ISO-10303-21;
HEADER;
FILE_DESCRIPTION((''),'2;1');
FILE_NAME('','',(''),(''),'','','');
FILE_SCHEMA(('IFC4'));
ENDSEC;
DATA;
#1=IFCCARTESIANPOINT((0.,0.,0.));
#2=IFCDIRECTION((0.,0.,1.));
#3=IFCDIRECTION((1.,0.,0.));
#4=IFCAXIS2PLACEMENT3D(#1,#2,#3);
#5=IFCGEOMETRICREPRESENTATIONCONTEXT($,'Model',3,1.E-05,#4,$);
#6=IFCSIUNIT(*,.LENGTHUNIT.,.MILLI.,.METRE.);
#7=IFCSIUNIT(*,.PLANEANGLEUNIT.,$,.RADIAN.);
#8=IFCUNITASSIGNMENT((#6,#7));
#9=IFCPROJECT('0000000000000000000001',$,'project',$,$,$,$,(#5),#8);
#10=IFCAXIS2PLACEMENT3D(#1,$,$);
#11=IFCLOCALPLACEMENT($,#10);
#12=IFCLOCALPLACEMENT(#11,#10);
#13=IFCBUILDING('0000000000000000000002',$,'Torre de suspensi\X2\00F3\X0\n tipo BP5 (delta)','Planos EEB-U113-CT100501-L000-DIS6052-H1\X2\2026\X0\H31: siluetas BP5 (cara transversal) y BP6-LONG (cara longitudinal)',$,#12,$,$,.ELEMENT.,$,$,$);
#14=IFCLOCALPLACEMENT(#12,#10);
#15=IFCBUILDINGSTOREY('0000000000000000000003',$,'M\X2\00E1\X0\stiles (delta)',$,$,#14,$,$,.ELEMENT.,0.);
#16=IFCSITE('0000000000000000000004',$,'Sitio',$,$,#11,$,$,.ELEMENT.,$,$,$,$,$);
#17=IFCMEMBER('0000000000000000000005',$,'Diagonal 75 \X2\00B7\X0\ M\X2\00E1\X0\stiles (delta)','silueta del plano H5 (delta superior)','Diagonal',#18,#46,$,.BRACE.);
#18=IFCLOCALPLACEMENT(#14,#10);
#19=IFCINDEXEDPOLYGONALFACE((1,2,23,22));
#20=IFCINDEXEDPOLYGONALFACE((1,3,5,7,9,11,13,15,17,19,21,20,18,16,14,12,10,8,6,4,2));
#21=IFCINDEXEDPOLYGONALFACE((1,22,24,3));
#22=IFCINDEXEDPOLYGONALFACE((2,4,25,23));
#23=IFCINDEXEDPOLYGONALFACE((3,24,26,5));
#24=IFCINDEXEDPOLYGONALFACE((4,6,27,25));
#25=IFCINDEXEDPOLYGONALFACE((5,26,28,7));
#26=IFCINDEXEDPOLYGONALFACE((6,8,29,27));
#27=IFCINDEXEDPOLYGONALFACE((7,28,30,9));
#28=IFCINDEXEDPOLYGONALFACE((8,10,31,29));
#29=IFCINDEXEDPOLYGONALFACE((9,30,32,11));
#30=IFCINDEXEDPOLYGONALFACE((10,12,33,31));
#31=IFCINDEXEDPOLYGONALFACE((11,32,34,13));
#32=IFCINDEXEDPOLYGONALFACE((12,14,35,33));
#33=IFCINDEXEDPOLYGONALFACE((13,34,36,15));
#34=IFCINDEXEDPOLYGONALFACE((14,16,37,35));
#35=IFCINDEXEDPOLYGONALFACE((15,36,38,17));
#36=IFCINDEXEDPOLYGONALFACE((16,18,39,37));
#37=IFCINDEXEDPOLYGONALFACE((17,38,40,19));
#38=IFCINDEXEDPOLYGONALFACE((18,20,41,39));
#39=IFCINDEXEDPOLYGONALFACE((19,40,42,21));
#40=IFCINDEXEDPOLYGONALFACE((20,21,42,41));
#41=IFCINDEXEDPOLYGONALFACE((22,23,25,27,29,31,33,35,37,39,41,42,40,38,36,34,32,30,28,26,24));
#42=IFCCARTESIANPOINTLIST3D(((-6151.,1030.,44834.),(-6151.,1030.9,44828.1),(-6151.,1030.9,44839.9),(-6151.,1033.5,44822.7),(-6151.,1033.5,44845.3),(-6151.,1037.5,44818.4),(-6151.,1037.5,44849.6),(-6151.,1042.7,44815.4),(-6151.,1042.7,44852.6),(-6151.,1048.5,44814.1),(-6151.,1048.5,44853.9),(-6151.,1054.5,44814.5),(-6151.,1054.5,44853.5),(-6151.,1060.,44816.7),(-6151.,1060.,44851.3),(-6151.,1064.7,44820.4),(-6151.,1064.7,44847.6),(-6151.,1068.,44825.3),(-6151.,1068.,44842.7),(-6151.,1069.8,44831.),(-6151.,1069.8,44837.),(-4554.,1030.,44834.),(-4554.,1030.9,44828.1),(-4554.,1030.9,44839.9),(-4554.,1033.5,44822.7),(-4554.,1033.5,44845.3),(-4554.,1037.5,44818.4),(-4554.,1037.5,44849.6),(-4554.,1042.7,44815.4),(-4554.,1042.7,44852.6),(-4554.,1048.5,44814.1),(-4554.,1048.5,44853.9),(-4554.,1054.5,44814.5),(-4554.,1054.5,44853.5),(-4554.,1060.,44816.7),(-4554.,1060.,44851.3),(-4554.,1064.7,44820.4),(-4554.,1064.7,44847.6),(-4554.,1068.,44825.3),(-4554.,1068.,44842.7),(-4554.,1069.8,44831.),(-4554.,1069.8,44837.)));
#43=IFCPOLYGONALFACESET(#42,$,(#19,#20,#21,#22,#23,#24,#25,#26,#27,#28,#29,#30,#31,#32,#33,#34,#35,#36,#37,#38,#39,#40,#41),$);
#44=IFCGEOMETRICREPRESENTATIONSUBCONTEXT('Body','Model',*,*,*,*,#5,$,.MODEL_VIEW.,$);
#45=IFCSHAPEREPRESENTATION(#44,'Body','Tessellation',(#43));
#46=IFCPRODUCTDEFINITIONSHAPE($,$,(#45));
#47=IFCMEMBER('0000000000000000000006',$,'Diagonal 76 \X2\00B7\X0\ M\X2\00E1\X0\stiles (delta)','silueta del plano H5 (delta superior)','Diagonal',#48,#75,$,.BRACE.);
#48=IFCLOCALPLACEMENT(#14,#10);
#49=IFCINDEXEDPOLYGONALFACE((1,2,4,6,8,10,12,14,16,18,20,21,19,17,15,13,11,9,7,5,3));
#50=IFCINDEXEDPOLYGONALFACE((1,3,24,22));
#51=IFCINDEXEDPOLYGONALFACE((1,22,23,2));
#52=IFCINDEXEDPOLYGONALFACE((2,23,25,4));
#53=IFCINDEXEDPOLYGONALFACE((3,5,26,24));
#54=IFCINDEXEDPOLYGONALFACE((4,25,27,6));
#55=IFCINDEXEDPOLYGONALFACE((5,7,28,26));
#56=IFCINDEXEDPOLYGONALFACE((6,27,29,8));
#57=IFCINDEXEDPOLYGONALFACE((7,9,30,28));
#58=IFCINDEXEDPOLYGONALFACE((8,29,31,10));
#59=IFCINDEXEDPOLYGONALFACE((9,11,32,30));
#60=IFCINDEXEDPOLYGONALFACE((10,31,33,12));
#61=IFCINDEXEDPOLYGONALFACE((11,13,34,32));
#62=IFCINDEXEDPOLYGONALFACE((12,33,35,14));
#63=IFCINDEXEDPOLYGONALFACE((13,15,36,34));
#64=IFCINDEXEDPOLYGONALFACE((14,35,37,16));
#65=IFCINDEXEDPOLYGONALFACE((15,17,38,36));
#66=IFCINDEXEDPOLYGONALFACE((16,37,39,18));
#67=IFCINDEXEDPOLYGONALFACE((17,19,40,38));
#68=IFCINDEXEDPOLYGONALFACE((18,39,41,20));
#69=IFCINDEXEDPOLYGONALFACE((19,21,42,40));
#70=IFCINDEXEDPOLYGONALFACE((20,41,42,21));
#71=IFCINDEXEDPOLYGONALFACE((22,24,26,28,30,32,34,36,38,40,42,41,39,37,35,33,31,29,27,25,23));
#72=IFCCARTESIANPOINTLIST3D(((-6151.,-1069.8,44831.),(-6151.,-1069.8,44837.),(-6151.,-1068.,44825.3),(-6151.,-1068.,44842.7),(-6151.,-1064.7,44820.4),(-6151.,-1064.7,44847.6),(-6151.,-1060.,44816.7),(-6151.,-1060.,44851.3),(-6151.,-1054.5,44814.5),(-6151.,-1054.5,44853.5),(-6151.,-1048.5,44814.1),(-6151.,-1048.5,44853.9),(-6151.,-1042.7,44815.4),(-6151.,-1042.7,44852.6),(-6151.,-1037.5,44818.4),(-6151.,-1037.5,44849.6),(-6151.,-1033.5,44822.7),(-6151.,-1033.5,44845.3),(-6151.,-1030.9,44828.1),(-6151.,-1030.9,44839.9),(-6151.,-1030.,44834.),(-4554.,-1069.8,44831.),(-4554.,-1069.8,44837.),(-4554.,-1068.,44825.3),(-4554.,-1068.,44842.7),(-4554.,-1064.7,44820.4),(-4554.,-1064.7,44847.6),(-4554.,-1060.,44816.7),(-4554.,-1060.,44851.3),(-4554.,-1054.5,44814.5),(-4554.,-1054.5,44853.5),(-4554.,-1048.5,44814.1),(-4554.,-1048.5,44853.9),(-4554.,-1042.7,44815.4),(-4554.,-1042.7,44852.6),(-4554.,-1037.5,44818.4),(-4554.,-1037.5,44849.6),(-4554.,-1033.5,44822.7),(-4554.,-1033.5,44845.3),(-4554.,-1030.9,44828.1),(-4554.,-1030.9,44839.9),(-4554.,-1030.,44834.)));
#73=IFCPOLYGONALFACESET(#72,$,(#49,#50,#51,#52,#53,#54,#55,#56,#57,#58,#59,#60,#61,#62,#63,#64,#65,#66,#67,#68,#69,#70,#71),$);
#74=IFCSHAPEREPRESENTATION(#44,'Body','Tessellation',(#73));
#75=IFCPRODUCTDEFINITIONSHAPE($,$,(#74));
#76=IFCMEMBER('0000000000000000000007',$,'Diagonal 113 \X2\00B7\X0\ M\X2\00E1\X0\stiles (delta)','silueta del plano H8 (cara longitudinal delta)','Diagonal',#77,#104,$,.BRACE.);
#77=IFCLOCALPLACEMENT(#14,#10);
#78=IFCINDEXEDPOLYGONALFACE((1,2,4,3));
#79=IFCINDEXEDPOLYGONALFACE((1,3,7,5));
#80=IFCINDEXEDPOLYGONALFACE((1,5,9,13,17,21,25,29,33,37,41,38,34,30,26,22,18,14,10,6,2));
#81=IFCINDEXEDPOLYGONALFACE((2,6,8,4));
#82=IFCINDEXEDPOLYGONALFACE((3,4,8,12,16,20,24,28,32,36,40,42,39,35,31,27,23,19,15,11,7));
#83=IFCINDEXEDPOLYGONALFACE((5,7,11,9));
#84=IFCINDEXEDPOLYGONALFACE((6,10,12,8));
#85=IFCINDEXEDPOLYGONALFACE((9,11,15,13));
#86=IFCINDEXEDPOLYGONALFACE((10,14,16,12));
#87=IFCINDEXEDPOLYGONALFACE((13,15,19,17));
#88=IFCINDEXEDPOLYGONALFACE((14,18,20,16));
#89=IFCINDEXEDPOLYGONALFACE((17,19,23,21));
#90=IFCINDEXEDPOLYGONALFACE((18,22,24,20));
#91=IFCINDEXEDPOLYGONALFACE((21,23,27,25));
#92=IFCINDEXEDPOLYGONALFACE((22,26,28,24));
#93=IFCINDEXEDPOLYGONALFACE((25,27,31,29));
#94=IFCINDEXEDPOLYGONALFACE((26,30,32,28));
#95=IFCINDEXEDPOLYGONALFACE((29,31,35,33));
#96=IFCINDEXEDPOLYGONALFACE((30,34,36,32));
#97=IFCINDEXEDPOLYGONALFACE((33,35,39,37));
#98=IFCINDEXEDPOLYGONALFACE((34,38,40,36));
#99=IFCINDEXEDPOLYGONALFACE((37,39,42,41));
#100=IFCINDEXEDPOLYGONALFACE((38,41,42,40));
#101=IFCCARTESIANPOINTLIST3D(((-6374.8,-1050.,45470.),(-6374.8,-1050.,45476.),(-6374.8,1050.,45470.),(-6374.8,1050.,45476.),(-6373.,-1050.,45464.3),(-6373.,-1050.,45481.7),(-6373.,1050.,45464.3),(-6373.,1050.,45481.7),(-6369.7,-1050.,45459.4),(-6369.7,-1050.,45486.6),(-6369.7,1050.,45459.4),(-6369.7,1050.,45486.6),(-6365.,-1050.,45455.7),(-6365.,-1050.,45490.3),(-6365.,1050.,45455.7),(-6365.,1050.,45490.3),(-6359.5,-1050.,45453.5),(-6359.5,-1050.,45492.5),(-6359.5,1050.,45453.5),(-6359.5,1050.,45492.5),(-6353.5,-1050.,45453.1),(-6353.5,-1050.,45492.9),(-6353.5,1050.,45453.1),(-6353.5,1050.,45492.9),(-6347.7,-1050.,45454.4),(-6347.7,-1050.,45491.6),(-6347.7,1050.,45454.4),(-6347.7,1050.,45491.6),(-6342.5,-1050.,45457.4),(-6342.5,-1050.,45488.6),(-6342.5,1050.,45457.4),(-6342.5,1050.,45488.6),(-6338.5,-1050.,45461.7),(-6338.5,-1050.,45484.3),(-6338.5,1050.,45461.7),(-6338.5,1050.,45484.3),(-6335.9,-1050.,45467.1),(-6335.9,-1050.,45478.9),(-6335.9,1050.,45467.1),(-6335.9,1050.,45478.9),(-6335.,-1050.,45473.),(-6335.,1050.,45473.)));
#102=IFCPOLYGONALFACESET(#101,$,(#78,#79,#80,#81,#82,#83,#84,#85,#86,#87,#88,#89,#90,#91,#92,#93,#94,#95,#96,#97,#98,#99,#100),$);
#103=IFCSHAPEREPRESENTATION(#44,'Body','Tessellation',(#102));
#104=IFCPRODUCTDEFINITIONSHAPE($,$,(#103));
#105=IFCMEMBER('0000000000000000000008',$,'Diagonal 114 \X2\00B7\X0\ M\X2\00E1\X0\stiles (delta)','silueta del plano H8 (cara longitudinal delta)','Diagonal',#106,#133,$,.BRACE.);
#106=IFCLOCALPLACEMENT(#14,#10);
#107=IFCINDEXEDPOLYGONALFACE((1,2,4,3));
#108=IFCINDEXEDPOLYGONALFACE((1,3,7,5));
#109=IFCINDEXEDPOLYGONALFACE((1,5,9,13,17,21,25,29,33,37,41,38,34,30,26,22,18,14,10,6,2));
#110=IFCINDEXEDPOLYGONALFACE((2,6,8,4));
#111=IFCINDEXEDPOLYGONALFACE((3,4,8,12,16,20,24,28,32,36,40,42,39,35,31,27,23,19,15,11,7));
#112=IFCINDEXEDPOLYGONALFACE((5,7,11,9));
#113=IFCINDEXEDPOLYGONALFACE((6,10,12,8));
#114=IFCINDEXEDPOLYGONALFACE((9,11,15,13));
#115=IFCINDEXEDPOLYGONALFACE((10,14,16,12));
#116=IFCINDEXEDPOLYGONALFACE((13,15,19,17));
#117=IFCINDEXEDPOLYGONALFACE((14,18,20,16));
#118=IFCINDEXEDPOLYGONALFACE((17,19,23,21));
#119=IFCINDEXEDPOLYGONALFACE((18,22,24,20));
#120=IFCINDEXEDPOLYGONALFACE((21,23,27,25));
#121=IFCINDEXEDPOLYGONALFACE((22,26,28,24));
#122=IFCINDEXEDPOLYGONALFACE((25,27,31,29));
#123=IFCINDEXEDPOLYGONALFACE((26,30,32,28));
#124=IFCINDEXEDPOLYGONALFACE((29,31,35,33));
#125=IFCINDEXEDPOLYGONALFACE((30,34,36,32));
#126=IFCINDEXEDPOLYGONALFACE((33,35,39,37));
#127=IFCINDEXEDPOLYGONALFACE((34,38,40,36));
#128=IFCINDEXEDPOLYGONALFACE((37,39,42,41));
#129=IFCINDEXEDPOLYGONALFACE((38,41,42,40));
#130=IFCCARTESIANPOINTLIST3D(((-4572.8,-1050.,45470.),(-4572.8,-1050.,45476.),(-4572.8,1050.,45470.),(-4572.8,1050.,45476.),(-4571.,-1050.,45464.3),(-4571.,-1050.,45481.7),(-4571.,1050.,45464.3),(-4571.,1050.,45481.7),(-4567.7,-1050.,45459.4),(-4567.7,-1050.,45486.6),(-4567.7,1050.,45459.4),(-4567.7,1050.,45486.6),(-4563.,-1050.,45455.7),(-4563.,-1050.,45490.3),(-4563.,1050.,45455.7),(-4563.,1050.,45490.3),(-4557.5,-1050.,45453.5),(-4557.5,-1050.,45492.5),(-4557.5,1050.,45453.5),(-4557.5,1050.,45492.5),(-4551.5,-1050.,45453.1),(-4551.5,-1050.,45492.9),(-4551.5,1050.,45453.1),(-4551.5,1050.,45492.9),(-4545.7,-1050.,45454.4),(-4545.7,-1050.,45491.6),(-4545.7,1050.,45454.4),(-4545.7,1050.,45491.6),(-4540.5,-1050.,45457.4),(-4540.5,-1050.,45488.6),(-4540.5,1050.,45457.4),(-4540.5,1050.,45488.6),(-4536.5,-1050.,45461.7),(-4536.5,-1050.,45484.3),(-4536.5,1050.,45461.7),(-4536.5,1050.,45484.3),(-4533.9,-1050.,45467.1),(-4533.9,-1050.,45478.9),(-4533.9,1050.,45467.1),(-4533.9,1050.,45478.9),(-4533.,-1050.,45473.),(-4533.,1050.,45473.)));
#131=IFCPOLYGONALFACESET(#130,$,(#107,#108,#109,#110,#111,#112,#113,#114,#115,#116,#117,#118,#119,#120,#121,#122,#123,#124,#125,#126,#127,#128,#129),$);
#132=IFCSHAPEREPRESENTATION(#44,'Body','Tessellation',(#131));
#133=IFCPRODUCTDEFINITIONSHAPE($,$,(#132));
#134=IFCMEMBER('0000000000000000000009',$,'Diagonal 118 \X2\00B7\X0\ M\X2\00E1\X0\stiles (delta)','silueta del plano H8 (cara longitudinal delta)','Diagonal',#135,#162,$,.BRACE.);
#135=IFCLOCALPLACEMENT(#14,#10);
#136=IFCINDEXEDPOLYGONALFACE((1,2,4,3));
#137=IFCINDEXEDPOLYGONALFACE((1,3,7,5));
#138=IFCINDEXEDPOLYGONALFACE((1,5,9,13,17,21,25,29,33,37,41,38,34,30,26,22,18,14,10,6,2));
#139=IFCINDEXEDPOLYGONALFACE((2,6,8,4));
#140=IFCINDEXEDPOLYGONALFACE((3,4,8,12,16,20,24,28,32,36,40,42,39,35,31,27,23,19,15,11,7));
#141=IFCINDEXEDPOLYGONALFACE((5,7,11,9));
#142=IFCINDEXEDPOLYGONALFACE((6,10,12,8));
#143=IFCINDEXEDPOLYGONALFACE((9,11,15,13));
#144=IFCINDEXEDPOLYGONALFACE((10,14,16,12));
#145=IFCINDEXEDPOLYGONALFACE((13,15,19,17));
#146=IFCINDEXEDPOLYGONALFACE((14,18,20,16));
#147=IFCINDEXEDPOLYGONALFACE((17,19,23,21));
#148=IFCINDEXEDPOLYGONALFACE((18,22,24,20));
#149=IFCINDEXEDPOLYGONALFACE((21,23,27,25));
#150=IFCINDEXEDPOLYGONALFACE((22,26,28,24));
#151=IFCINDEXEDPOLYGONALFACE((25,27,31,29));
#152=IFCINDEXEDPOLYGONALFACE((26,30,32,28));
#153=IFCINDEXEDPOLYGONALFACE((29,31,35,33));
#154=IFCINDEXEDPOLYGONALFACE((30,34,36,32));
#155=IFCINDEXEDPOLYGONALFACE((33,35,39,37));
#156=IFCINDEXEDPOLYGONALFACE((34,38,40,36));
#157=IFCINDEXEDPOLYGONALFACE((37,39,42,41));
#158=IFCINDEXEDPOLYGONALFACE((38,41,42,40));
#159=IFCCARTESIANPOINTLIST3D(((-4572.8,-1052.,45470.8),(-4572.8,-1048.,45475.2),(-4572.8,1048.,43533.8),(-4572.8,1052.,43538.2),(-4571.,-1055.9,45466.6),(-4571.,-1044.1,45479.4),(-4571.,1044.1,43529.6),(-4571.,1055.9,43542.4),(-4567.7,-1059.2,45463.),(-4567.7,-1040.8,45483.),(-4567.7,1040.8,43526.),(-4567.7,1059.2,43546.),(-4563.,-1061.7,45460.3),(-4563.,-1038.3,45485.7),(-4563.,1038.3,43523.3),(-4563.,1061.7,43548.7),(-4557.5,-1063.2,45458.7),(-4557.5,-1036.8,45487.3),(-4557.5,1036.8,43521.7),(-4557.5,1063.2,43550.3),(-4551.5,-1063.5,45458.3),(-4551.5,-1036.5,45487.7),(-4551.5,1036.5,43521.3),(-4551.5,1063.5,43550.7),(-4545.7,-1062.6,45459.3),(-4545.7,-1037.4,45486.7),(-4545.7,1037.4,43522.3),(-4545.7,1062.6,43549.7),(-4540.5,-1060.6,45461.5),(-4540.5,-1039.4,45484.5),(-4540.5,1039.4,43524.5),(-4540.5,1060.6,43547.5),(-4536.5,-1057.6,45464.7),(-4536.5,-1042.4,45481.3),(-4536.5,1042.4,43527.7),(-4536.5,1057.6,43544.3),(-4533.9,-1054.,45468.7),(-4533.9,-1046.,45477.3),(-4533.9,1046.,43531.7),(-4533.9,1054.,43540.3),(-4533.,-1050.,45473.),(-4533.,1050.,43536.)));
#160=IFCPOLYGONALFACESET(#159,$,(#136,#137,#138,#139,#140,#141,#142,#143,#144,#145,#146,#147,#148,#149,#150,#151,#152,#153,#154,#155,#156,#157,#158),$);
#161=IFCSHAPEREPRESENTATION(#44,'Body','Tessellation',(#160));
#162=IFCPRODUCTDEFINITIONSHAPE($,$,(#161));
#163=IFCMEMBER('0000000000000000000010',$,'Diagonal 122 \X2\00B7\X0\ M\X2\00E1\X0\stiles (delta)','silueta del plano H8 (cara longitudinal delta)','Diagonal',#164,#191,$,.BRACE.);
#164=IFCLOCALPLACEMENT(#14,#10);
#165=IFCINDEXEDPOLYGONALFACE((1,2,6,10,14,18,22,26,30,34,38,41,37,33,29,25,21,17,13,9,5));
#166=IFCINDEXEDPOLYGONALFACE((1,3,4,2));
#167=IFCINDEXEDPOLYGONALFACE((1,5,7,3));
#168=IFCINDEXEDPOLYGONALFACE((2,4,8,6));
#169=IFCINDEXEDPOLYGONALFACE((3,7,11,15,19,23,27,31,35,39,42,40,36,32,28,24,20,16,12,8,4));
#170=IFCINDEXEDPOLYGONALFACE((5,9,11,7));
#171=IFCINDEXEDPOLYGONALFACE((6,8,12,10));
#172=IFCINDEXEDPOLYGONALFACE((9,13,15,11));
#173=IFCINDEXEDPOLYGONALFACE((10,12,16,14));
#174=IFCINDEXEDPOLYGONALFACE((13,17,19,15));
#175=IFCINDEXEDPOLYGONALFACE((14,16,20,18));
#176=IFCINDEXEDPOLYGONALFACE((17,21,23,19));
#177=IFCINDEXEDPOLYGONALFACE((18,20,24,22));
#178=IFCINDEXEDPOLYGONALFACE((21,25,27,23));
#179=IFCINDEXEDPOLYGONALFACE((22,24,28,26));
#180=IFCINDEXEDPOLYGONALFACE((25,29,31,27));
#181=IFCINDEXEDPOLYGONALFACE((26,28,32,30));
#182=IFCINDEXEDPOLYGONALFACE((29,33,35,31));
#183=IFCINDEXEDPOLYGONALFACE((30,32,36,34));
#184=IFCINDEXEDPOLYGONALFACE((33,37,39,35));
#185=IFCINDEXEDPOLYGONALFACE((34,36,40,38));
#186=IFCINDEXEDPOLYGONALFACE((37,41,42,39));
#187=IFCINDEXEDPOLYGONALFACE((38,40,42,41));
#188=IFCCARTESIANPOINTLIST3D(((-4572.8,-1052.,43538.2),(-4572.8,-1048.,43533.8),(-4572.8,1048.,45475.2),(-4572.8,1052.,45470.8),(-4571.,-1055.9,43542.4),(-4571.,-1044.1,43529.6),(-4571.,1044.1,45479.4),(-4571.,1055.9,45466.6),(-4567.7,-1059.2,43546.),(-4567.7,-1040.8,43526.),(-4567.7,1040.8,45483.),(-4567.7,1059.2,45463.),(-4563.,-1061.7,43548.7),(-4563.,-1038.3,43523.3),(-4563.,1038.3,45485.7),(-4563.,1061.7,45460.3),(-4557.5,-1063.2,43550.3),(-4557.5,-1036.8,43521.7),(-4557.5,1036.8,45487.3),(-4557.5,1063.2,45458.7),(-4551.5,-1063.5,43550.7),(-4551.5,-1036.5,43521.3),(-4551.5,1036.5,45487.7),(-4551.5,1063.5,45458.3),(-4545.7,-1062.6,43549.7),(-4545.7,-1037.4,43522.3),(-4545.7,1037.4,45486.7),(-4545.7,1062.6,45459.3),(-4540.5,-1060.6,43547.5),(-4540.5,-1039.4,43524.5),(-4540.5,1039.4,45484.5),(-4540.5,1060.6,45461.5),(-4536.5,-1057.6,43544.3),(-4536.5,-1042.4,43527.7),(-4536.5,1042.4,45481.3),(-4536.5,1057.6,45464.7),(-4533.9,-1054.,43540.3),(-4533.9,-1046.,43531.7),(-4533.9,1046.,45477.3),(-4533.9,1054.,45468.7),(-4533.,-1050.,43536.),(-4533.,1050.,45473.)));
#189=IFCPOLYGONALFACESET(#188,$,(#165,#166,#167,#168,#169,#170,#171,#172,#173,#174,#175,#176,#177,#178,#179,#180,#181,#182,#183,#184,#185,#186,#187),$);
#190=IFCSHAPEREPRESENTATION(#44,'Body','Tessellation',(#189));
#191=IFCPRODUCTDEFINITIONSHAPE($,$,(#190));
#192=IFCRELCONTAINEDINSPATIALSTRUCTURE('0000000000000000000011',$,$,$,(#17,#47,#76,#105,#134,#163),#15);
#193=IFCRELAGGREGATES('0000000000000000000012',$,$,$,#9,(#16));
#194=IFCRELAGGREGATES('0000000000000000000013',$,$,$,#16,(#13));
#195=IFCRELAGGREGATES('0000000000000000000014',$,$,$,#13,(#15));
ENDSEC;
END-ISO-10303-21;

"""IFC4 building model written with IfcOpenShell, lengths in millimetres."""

from ifc_helpers import new_model, si_unit, frame, origin, origin_with_axes, place, context, subcontext, project, spatial, circle, extrude, element, save


model = new_model("IFC4")

# Units and contexts
model_context = context("Model", 3, precision=1e-05, world=origin_with_axes())
body_context = subcontext(model_context, "Body", "Model", "MODEL_VIEW")
ifc_project = project(units=[si_unit("LENGTHUNIT", "METRE", prefix="MILLI"), si_unit("PLANEANGLEUNIT", "RADIAN")], contexts=[model_context])

# Site, building, storey
site_placement = place(None, origin())
site = spatial("IfcSite", under=ifc_project, at=site_placement, Name="Sitio", CompositionType="ELEMENT")
building_placement = place(site_placement, origin())
building = spatial("IfcBuilding", under=site, at=building_placement, Name="Torre de suspensión tipo BP5 (delta)", Description="Planos EEB-U113-CT100501-L000-DIS6052-H1…H31: siluetas BP5 (cara transversal) y BP6-LONG (cara longitudinal)", CompositionType="ELEMENT")
storey_placement = place(building_placement, origin())
storey = spatial("IfcBuildingStorey", under=building, at=storey_placement, Name="Mástiles (delta)", CompositionType="ELEMENT", Elevation=0.0)

# Members
for number, where, z_axis, x_axis, name in (
    (1, (-4554.0, 1050.0, 44834.0), (-1.0, 0.0, 0.0), (0.0, -1.0, 0.0), "Diagonal 75 · Mástiles (delta)"),
    (2, (-4554.0, -1050.0, 44834.0), (-1.0, 0.0, 0.0), (0.0, 1.0, 0.0), "Diagonal 76 · Mástiles (delta)"),
):
    element("IfcMember", number, at=place(storey_placement, frame(where, z_axis=z_axis, x_axis=x_axis)), inside=storey, Name=name, Description="silueta del plano H5 (delta superior)", ObjectType="Diagonal", PredefinedType="BRACE", context=body_context, shape_type="SweptSolid", body=[
        extrude(circle(Radius=20.0), None, (0.0, 0.0, 1.0), 1597.0),
    ])
for number, where, z_axis, x_axis, name in (
    (3, (-6355.0, -1050.0, 45473.0), (0.0, 1.0, 0.0), (1.0, 0.0, 0.0), "Diagonal 113 · Mástiles (delta)"),
    (4, (-4553.0, -1050.0, 45473.0), (0.0, 1.0, 0.0), (1.0, 0.0, 0.0), "Diagonal 114 · Mástiles (delta)"),
):
    element("IfcMember", number, at=place(storey_placement, frame(where, z_axis=z_axis, x_axis=x_axis)), inside=storey, Name=name, Description="silueta del plano H8 (cara longitudinal delta)", ObjectType="Diagonal", PredefinedType="BRACE", context=body_context, shape_type="SweptSolid", body=[
        extrude(circle(Radius=20.0), None, (0.0, 0.0, 1.0), 2100.0),
    ])
member_1_placement = place(storey_placement, frame((-4553.0, -1050.0, 45473.0), z_axis=(0.0, 0.735058, -0.678004), x_axis=(1.0, 0.0, 0.0)))
element("IfcMember", 5, at=member_1_placement, inside=storey, Name="Diagonal 118 · Mástiles (delta)", Description="silueta del plano H8 (cara longitudinal delta)", ObjectType="Diagonal", PredefinedType="BRACE", context=body_context, shape_type="SweptSolid", body=[
    extrude(circle(Radius=20.0), None, (0.0, 0.0, 1.0), 2856.9),
])
member_2_placement = place(storey_placement, frame((-4553.0, 1050.0, 45473.0), z_axis=(0.0, -0.735058, -0.678004), x_axis=(1.0, 0.0, 0.0)))
element("IfcMember", 6, at=member_2_placement, inside=storey, Name="Diagonal 122 · Mástiles (delta)", Description="silueta del plano H8 (cara longitudinal delta)", ObjectType="Diagonal", PredefinedType="BRACE", context=body_context, shape_type="SweptSolid", body=[
    extrude(circle(Radius=20.0), None, (0.0, 0.0, 1.0), 2856.9),
])

save(model, "model.ifc")
